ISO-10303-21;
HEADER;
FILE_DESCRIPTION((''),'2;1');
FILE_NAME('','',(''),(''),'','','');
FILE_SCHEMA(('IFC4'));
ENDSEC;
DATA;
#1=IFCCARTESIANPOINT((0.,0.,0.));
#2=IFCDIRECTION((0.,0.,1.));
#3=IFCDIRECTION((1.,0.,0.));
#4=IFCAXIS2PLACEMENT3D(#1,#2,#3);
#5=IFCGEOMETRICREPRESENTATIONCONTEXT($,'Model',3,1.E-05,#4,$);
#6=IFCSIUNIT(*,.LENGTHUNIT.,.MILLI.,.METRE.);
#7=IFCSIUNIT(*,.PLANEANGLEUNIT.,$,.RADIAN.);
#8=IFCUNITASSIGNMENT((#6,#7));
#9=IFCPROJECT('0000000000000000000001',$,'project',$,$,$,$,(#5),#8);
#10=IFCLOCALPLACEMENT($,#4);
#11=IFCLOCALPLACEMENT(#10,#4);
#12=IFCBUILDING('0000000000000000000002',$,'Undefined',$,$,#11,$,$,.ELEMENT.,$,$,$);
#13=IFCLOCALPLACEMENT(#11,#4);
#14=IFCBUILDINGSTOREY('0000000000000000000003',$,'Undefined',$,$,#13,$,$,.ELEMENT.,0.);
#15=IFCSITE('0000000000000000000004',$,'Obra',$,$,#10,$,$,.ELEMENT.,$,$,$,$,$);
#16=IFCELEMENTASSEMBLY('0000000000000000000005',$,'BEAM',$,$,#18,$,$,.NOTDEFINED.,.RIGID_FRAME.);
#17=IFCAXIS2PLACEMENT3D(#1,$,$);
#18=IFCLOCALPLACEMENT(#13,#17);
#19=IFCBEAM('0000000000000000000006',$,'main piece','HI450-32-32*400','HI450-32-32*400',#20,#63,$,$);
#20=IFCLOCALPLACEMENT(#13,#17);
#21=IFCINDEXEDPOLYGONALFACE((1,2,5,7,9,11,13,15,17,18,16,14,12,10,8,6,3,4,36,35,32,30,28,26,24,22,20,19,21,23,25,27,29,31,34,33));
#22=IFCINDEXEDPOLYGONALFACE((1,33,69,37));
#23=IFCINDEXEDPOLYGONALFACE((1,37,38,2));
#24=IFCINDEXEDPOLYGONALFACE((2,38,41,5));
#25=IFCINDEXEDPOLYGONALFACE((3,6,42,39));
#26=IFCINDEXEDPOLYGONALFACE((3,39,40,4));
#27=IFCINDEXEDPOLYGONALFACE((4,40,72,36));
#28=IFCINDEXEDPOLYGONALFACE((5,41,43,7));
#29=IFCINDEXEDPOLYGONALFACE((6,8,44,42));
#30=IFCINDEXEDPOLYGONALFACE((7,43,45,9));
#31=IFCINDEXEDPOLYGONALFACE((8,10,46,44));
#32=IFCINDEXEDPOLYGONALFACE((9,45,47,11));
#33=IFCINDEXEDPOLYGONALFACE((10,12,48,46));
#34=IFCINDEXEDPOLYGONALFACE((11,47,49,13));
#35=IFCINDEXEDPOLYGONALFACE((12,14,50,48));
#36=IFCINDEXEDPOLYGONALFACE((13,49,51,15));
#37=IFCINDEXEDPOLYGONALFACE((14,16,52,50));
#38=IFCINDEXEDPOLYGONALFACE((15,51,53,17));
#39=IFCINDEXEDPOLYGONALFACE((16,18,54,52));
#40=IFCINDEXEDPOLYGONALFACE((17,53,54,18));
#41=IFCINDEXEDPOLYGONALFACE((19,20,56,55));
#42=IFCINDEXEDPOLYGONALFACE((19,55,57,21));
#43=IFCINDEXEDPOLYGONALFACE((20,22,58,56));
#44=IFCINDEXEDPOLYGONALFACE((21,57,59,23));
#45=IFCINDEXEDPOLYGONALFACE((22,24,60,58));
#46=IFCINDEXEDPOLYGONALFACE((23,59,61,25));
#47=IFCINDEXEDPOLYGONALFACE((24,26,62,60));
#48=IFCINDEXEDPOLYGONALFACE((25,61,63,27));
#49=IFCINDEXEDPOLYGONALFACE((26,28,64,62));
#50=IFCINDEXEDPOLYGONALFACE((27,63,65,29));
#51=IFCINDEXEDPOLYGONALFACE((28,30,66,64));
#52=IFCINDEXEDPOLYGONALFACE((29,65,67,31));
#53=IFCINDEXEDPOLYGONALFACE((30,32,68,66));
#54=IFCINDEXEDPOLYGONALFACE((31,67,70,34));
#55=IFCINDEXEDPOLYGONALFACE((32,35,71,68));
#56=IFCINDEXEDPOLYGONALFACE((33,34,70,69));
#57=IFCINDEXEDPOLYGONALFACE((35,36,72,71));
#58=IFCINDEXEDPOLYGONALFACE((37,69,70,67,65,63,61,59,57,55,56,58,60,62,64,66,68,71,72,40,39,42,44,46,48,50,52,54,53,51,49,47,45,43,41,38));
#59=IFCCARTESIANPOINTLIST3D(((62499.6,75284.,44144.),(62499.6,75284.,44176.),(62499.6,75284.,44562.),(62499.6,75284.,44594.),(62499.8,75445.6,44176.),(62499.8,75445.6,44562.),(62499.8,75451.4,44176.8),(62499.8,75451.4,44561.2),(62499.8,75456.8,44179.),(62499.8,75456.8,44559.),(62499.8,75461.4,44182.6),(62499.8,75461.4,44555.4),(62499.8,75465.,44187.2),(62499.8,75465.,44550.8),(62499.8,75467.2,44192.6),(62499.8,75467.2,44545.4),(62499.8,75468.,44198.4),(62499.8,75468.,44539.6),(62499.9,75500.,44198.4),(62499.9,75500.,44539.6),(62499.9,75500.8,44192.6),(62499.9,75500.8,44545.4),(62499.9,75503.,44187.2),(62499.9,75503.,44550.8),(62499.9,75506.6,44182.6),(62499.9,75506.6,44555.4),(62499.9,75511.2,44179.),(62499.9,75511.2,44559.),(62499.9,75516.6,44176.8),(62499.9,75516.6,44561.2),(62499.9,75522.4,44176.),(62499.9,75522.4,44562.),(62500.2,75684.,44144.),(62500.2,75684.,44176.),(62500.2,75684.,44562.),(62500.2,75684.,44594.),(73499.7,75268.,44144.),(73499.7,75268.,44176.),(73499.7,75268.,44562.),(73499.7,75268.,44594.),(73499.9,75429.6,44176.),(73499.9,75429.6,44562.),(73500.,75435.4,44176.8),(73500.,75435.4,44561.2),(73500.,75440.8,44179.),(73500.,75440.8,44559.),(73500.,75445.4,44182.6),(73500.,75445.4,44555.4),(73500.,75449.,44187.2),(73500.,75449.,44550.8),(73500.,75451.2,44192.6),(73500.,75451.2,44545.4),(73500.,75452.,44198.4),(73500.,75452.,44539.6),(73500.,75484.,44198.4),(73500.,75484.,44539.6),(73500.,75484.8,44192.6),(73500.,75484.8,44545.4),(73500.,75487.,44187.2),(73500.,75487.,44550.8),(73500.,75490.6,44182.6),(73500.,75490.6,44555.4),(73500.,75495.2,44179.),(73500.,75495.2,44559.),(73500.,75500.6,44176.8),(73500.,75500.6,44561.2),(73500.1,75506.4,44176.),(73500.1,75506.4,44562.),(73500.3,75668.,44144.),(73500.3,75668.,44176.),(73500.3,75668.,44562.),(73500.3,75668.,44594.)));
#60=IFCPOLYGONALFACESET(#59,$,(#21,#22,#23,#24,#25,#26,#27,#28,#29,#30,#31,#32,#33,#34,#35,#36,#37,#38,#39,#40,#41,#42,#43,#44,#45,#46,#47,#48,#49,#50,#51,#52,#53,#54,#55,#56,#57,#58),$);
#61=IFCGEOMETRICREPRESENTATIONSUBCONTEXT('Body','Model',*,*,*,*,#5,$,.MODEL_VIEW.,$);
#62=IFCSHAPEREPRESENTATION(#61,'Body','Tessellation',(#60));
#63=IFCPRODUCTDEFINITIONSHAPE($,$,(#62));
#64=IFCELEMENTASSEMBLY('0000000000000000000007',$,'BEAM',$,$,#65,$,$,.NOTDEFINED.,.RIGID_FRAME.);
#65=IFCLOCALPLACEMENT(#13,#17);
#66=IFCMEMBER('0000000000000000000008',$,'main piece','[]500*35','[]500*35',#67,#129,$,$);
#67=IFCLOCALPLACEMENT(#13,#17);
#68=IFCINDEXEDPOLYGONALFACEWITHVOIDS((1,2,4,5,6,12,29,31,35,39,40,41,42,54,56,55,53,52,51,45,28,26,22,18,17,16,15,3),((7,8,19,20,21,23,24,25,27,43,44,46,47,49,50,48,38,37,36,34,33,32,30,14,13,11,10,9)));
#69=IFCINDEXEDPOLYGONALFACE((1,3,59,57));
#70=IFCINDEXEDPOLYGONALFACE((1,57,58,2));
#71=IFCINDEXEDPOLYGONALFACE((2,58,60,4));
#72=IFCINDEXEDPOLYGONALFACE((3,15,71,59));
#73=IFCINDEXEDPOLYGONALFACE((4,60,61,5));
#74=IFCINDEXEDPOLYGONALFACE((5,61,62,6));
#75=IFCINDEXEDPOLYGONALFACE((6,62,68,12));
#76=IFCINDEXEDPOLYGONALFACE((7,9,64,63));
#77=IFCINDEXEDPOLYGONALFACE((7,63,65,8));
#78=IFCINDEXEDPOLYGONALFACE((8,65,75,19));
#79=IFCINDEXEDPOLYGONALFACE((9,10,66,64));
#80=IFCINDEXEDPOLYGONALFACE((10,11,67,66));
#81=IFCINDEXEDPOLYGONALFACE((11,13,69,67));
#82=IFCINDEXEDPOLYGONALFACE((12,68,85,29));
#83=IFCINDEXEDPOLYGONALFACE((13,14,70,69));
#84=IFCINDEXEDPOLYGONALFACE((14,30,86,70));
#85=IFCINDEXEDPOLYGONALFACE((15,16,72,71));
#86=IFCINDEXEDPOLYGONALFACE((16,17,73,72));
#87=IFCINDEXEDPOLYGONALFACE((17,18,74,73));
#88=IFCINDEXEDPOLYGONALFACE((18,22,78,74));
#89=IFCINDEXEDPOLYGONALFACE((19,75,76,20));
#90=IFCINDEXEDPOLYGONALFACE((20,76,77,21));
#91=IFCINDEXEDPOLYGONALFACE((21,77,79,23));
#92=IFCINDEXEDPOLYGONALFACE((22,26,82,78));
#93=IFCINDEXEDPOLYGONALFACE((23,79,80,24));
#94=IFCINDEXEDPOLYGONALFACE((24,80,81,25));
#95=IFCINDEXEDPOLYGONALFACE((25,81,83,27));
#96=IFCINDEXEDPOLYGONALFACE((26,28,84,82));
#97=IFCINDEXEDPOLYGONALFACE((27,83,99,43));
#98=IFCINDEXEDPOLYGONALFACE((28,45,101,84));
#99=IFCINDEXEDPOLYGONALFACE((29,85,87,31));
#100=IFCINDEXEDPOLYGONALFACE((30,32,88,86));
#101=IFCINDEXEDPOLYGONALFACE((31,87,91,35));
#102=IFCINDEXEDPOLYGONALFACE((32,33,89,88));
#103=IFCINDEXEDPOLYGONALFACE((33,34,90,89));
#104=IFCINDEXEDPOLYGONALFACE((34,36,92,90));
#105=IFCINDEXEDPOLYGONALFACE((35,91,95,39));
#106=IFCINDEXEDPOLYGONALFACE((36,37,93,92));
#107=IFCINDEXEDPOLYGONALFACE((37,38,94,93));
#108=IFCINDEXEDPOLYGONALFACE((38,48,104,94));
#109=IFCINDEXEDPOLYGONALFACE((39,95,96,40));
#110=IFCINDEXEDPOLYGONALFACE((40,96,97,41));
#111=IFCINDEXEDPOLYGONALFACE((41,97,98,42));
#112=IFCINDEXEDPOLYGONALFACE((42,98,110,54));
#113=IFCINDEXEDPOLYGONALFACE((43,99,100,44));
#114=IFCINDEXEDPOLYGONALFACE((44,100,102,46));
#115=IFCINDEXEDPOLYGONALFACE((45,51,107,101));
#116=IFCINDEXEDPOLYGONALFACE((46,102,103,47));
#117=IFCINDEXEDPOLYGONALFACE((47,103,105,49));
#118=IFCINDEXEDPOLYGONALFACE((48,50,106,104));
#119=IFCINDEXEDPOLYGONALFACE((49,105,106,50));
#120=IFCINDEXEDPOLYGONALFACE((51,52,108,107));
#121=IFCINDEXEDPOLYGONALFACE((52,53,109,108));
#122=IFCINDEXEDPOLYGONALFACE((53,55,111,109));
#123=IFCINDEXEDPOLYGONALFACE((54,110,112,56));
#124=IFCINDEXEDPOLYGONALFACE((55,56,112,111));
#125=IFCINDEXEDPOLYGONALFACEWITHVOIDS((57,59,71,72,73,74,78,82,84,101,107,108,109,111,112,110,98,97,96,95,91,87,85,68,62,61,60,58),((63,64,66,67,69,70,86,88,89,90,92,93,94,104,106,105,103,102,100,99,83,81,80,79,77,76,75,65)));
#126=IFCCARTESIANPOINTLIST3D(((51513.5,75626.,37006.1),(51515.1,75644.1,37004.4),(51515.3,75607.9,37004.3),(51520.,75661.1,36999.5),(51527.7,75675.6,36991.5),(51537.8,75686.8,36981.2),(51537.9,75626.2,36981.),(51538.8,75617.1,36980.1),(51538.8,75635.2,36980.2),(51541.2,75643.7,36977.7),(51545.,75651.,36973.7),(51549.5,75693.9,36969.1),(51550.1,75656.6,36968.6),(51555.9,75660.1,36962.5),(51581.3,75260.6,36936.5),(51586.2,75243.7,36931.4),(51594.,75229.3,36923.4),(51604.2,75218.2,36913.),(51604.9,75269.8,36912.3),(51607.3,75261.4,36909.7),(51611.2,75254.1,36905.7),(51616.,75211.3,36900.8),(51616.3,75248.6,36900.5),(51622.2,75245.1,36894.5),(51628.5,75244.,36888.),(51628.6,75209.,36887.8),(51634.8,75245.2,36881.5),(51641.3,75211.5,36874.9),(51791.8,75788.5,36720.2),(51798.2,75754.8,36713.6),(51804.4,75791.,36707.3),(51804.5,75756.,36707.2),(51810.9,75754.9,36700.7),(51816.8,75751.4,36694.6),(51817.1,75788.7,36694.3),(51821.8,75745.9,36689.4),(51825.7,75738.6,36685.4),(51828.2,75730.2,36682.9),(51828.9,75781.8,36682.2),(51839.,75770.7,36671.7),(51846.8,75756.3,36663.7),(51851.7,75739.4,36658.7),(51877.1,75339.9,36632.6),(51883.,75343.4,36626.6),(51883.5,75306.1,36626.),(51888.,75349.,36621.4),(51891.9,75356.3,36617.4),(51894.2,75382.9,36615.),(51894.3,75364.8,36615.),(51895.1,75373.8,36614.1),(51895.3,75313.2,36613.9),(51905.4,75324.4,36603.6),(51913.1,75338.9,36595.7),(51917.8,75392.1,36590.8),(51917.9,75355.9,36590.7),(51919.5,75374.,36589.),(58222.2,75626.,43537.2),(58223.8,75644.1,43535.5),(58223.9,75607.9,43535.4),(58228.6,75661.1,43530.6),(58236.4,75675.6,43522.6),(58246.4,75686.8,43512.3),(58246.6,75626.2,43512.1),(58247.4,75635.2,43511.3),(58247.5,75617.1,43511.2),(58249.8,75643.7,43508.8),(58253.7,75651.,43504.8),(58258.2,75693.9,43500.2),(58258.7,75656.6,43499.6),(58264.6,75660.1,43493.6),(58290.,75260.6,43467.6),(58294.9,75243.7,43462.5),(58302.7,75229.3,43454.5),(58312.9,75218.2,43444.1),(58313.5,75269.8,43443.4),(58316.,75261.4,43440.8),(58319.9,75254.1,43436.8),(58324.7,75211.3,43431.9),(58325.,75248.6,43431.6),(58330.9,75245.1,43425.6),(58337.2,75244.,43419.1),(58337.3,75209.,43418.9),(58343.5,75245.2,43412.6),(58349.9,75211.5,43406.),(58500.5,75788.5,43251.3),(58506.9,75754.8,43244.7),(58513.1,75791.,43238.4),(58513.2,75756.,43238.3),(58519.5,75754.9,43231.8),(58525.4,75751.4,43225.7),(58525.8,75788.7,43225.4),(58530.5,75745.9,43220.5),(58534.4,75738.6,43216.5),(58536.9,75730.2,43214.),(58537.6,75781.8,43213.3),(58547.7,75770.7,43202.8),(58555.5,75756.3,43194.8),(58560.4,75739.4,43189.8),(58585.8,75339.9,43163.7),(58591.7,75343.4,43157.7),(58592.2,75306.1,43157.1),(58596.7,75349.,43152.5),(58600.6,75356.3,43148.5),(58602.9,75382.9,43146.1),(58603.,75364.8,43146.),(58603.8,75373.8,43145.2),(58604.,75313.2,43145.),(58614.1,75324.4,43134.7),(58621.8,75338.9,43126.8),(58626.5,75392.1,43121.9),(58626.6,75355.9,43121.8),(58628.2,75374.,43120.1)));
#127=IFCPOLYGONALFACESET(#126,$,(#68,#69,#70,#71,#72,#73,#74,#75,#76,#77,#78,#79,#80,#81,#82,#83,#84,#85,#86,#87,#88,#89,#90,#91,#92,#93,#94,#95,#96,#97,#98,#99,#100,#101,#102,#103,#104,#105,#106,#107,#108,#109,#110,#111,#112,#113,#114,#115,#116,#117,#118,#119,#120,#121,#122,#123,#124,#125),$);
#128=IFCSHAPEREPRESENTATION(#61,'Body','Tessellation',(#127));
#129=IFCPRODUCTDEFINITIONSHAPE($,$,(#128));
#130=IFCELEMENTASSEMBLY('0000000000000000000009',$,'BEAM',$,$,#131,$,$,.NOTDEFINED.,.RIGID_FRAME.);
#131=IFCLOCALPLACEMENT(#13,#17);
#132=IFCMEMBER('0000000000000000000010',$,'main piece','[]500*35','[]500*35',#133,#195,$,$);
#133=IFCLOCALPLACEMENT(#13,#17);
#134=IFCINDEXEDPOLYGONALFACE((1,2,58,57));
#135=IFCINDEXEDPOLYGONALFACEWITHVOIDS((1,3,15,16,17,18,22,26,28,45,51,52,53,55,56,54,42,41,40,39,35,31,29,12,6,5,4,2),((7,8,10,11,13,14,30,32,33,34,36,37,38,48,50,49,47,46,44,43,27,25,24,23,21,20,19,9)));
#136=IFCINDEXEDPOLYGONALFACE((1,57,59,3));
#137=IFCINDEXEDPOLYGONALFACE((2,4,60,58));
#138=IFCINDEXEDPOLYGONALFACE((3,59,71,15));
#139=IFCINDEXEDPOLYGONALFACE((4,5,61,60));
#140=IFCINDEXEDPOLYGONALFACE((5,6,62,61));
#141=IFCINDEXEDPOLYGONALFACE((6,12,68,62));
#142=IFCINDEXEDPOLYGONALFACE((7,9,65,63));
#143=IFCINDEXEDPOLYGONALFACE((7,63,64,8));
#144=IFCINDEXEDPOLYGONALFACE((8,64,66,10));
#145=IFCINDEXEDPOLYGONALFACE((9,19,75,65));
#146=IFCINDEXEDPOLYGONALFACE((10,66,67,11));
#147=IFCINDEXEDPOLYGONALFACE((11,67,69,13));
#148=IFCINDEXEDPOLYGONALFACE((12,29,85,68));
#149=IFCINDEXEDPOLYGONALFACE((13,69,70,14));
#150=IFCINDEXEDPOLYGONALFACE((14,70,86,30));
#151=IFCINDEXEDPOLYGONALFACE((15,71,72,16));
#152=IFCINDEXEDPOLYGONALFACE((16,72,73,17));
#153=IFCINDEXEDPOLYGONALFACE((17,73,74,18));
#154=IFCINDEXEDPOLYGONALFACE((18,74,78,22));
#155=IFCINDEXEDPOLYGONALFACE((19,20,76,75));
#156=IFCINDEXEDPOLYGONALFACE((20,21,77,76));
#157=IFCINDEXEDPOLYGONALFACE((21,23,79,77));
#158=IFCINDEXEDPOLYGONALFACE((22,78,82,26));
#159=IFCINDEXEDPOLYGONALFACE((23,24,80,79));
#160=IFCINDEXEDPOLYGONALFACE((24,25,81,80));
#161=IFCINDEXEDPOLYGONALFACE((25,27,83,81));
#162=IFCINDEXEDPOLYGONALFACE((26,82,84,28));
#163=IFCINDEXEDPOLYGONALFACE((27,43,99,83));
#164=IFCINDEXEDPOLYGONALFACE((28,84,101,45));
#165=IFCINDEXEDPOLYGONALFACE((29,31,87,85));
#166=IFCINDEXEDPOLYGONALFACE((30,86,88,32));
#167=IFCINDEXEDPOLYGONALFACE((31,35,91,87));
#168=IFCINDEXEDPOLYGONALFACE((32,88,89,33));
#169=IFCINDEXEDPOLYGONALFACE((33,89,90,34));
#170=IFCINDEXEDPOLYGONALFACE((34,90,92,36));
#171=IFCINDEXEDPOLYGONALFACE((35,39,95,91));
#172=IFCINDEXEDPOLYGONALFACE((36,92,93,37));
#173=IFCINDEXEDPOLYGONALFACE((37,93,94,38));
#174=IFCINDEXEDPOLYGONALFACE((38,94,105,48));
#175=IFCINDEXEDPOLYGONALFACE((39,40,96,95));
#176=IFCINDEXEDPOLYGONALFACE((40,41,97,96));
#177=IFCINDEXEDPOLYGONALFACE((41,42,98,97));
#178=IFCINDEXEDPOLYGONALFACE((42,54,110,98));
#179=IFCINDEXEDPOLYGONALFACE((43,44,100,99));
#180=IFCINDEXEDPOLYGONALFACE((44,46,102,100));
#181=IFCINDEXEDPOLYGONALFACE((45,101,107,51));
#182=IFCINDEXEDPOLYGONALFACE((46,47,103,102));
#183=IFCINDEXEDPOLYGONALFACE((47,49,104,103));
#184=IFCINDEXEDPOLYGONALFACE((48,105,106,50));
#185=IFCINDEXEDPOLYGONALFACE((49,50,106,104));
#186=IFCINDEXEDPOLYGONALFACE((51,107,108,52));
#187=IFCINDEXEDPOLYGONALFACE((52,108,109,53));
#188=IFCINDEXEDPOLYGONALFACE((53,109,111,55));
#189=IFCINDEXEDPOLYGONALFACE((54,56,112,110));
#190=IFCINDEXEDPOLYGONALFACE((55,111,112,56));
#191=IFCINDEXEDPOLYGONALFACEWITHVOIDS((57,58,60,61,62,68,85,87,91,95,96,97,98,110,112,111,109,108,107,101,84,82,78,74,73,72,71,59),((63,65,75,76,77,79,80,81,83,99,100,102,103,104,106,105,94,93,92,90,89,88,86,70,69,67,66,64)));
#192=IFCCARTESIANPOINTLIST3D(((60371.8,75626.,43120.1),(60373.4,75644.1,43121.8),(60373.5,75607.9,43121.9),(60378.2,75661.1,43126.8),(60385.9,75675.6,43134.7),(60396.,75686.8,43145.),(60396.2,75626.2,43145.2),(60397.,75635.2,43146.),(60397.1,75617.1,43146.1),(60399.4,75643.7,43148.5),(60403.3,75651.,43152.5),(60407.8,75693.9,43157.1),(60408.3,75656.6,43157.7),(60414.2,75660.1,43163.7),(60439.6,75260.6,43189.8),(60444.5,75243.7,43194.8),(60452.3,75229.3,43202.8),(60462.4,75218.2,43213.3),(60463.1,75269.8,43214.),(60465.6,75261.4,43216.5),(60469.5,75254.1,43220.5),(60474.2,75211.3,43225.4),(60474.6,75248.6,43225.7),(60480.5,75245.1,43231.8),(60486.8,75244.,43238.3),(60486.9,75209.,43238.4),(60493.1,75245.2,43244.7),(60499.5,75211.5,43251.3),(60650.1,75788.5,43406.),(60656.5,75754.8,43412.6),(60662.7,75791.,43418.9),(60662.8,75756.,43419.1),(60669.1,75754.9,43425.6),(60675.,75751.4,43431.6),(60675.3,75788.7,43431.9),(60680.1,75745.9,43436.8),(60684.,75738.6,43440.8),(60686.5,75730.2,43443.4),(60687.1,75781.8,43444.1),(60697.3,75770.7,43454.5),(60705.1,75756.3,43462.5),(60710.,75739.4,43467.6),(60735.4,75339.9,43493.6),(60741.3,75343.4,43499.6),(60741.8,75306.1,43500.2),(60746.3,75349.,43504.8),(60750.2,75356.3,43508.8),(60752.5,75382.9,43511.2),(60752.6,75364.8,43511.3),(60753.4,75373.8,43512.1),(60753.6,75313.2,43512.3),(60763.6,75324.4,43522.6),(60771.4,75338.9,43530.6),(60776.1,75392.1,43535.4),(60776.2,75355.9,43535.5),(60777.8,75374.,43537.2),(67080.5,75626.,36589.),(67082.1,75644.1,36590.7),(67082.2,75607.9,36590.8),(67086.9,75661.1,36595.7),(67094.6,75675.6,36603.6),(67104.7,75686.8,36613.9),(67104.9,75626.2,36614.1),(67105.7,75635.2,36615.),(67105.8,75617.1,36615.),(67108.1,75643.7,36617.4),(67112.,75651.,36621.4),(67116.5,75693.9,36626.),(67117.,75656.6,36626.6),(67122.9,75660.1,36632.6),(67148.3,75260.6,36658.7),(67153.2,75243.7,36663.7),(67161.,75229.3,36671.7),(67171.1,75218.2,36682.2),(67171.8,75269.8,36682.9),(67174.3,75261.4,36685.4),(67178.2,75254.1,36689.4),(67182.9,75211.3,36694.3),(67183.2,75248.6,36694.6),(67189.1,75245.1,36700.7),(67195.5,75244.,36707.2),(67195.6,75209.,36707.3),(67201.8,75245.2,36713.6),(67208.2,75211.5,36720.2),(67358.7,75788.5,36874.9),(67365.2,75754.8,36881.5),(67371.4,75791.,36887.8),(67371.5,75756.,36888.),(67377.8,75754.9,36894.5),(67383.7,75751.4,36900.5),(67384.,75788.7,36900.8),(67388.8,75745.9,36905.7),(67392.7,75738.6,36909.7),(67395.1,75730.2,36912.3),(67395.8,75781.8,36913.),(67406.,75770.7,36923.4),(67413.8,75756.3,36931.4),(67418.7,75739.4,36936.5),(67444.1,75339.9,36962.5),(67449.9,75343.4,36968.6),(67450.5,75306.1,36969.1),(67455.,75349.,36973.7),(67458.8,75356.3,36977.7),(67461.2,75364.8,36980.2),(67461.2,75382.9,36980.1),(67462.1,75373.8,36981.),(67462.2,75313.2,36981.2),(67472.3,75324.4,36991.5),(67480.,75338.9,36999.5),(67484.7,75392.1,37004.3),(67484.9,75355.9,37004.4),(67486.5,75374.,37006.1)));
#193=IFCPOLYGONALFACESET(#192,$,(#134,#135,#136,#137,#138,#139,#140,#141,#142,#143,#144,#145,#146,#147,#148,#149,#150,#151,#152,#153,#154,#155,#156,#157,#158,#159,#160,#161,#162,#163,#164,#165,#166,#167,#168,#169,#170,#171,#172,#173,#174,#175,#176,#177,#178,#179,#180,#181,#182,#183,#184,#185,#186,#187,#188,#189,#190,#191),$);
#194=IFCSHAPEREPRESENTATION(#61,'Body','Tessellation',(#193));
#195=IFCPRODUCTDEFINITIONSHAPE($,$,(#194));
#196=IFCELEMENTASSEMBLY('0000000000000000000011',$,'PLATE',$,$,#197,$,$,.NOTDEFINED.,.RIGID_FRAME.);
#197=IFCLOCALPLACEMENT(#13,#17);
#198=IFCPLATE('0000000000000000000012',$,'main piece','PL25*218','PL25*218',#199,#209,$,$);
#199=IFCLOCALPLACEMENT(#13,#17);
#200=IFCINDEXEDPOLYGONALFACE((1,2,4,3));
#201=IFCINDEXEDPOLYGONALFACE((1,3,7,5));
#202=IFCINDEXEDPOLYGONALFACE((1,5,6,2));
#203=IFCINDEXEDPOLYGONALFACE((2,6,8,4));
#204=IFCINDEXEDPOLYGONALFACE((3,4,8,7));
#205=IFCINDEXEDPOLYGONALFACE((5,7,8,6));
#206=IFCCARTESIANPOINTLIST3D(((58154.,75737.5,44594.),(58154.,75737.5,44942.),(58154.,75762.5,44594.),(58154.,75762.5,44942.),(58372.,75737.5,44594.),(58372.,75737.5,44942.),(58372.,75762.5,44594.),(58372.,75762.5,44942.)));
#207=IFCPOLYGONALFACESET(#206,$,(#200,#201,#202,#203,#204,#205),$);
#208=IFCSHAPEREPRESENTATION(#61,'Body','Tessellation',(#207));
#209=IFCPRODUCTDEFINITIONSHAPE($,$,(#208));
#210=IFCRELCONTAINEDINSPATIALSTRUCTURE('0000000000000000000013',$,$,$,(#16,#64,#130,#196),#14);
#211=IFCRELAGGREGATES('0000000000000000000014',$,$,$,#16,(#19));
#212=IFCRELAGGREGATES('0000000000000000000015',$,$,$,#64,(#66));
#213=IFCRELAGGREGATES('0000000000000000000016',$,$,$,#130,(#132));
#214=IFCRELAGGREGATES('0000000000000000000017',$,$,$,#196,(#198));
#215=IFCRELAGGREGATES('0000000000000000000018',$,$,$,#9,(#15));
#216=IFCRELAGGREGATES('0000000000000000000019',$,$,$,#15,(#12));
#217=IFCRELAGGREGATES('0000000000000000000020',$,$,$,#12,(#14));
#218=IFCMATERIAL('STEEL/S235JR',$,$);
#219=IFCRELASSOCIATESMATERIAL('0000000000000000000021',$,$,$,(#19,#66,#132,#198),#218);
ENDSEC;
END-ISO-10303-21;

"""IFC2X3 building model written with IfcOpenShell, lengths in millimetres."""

from ifc_helpers import new_model, si_unit, frame, origin_with_axes, origin_2d_with_axis, place, context, subcontext, project, spatial, polyline, hollow_rectangle, i_section, outline, extrude, material, element, aggregate, save


model = new_model("IFC2X3")

# Units and contexts
model_context = context("Model", 3, precision=1e-05, world=origin_with_axes())
body_context = subcontext(model_context, "Body", "Model", "MODEL_VIEW")
ifc_project = project(units=[si_unit("LENGTHUNIT", "METRE", prefix="MILLI"), si_unit("PLANEANGLEUNIT", "RADIAN")], contexts=[model_context])

# Site, building, storey
site_placement = place(None, origin_with_axes())
site = spatial("IfcSite", under=ifc_project, at=site_placement, Name="Obra", CompositionType="ELEMENT")
building_placement = place(site_placement, origin_with_axes())
building = spatial("IfcBuilding", under=site, at=building_placement, Name="Undefined", CompositionType="ELEMENT")
storey_placement = place(building_placement, origin_with_axes())
storey = spatial("IfcBuildingStorey", under=building, at=storey_placement, Name="Undefined", CompositionType="ELEMENT", Elevation=0.0)

# Element assembly, beam
assembly_1_placement = place(storey_placement, origin_with_axes())
assembly_1 = element("IfcElementAssembly", 1, at=assembly_1_placement, inside=storey, Name="BEAM", AssemblyPlace="NOTDEFINED", PredefinedType="RIGID_FRAME")
ifc_material = material(Name="STEEL/S235JR")
beam_placement = place(assembly_1_placement, frame((73500.0, 75468.0, 44369.0), z_axis=(0.0, 0.0, 1.0), x_axis=(-0.999999, 0.001455, 0.0)))
beam = element("IfcBeam", 2, at=beam_placement, material=ifc_material, Name="main piece", Description="HI450-32-32*400", ObjectType="HI450-32-32*400", context=body_context, shape_type="SweptSolid", body=[
    extrude(i_section(OverallWidth=400.0, OverallDepth=450.0, WebThickness=32.0, FlangeThickness=32.0, FilletRadius=22.4, at=origin_2d_with_axis()), frame((11000.2, 0.0, 0.0), z_axis=(-1.0, 0.0, 0.0), x_axis=(0.0, -1.0, 0.0)), (0.0, 0.0, 1.0), 11000.1),
])
aggregate(assembly_1, [beam])

# Element assemblies, members
assembly_2_placement = place(storey_placement, origin_with_axes())
assembly_2 = element("IfcElementAssembly", 3, at=assembly_2_placement, inside=storey, Name="BEAM", AssemblyPlace="NOTDEFINED", PredefinedType="RIGID_FRAME")
member_1_placement = place(assembly_2_placement, frame((58425.2, 75500.0, 43328.7), z_axis=(-0.672997, -0.26303, 0.691296), x_axis=(-0.716527, 0.0, -0.69756)))
member_1 = element("IfcMember", 4, at=member_1_placement, material=ifc_material, Name="main piece", Description="[]500*35", ObjectType="[]500*35", context=body_context, shape_type="SweptSolid", body=[
    extrude(hollow_rectangle(XDim=500.0, YDim=500.0, WallThickness=35.0, InnerFilletRadius=35.0, OuterFilletRadius=70.0, at=origin_2d_with_axis()), frame((9362.8, 0.0, 0.0), z_axis=(-1.0, 0.0, 0.0), x_axis=(0.0, -1.0, 0.0)), (0.0, 0.0, 1.0), 9362.8),
])
aggregate(assembly_2, [member_1])
assembly_3_placement = place(storey_placement, origin_with_axes())
assembly_3 = element("IfcElementAssembly", 5, at=assembly_3_placement, inside=storey, Name="BEAM", AssemblyPlace="NOTDEFINED", PredefinedType="RIGID_FRAME")
member_2_placement = place(assembly_3_placement, frame((60574.8, 75500.0, 43328.7), z_axis=(-0.672997, -0.26303, -0.691296), x_axis=(0.716527, 0.0, -0.69756)))
member_2 = element("IfcMember", 6, at=member_2_placement, material=ifc_material, Name="main piece", Description="[]500*35", ObjectType="[]500*35", context=body_context, shape_type="SweptSolid", body=[
    extrude(hollow_rectangle(XDim=500.0, YDim=500.0, WallThickness=35.0, InnerFilletRadius=35.0, OuterFilletRadius=70.0, at=origin_2d_with_axis()), frame((9362.8, 0.0, 0.0), z_axis=(-1.0, 0.0, 0.0), x_axis=(0.0, -1.0, 0.0)), (0.0, 0.0, 1.0), 9362.8),
])
aggregate(assembly_3, [member_2])

# Element assembly, plate
assembly_4_placement = place(storey_placement, origin_with_axes())
assembly_4 = element("IfcElementAssembly", 7, at=assembly_4_placement, inside=storey, Name="PLATE", AssemblyPlace="NOTDEFINED", PredefinedType="RIGID_FRAME")
plate_1_placement = place(assembly_4_placement, frame((58154.0, 75750.0, 44594.0), z_axis=(0.0, -1.0, 0.0), x_axis=(1.0, 0.0, 0.0)))
plate_1 = element("IfcPlate", 8, at=plate_1_placement, material=ifc_material, Name="main piece", Description="PL25*218", ObjectType="PL25*218", context=body_context, shape_type="SweptSolid", body=[
    extrude(outline(polyline([(0.0, 0.0), (218.0, 0.0), (218.0, 348.0), (0.0, 348.0), (0.0, 0.0)])), frame((0.0, 0.0, -12.5), z_axis=(0.0, 0.0, 1.0), x_axis=(1.0, 0.0, 0.0)), (0.0, 0.0, 1.0), 25.0),
])
aggregate(assembly_4, [plate_1])

save(model, "model.ifc")
